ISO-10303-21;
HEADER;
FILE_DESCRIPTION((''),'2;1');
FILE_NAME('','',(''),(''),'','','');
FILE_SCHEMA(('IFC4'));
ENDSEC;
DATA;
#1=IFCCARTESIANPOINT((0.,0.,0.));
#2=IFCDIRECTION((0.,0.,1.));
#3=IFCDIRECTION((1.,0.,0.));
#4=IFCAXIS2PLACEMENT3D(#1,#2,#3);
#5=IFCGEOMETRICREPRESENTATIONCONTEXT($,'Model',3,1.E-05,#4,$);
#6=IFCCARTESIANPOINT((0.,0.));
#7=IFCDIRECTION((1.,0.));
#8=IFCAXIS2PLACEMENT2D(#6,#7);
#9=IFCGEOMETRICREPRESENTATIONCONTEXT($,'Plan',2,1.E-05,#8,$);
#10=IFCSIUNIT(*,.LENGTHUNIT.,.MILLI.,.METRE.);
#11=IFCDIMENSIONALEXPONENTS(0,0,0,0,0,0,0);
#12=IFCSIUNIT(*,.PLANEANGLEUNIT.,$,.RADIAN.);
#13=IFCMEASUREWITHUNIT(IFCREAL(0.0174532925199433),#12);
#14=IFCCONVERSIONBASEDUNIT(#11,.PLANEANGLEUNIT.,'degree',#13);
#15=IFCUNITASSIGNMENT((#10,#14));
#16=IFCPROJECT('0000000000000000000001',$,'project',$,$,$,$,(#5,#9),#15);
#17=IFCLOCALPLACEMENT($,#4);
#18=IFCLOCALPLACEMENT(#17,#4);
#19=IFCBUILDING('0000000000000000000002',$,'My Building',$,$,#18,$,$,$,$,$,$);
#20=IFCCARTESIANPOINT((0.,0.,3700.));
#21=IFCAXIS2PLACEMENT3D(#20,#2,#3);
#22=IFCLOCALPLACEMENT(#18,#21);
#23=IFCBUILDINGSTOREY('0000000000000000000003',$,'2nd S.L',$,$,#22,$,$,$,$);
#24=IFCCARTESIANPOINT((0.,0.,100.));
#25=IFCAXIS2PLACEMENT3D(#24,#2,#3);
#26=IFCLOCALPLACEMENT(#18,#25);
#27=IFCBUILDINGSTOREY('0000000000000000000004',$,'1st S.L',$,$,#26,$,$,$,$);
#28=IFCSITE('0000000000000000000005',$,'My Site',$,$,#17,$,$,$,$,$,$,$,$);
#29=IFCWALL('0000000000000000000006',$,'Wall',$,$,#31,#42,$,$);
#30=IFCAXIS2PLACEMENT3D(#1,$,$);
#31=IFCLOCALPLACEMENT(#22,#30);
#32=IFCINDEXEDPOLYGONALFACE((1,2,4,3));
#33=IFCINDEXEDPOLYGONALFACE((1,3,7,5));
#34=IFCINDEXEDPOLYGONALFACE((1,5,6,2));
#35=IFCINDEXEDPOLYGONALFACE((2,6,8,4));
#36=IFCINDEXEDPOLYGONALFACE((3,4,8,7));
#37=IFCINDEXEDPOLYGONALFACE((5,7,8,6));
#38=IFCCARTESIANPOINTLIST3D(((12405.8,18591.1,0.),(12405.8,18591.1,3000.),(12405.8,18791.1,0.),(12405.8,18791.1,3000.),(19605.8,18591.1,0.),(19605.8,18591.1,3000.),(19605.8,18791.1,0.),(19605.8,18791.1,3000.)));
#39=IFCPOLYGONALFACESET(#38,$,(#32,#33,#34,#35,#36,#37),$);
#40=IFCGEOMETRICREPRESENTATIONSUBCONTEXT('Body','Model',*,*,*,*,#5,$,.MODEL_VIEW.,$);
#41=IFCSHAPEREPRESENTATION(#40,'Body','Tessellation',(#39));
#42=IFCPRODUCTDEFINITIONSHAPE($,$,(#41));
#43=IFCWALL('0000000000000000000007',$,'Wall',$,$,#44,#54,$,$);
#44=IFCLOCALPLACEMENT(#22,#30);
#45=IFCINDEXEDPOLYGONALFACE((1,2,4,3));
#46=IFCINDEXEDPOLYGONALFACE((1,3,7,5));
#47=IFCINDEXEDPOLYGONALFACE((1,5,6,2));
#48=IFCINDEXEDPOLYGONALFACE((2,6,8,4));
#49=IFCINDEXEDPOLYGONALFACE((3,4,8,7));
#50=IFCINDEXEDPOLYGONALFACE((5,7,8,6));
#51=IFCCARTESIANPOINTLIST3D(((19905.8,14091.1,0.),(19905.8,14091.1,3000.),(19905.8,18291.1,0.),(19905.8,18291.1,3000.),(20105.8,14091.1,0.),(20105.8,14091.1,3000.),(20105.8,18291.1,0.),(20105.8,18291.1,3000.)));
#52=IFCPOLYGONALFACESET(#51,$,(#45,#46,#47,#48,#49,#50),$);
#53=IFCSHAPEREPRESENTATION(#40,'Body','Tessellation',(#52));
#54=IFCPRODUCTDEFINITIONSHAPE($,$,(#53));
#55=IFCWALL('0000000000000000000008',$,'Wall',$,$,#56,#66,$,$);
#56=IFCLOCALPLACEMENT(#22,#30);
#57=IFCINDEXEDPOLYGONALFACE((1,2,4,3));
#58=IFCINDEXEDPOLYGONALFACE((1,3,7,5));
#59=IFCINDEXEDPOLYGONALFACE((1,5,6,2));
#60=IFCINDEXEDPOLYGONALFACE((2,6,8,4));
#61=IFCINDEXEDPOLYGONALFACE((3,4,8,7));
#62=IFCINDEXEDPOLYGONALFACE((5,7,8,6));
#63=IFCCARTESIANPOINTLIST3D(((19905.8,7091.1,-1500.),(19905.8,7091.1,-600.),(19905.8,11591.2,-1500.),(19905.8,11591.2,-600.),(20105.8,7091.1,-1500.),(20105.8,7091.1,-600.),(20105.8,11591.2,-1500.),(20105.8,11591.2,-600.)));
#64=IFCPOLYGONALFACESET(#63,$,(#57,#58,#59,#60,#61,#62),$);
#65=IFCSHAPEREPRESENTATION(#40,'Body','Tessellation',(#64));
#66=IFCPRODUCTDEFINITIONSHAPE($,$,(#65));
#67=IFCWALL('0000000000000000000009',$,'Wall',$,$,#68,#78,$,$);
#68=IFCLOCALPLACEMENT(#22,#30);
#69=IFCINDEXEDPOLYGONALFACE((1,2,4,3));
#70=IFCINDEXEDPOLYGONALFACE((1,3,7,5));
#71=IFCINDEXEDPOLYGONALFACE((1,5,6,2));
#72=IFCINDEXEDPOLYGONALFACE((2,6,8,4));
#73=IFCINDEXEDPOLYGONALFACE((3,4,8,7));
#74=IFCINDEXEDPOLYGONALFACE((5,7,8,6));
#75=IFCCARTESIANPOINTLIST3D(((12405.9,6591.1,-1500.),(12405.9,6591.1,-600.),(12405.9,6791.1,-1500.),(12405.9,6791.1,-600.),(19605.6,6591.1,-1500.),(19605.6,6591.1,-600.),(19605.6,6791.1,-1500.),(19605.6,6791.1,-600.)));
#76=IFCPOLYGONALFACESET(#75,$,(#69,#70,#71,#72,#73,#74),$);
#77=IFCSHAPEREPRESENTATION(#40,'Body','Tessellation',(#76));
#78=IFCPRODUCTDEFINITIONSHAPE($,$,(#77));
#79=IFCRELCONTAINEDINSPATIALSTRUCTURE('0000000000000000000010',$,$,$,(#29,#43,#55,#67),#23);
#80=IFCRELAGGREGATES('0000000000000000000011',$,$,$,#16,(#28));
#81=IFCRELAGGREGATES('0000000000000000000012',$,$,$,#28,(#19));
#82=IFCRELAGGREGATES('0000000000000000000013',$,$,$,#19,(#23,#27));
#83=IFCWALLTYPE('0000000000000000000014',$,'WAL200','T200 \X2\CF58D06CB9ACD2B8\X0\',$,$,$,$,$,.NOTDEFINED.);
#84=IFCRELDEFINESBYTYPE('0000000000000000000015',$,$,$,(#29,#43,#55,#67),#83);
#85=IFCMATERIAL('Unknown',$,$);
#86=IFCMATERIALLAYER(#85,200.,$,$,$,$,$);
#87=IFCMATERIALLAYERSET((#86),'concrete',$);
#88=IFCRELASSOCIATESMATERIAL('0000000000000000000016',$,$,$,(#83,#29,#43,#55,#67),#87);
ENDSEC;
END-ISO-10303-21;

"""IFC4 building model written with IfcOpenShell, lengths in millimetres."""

from ifc_helpers import new_model, entity, si_unit, converted_unit, frame, origin_with_axes, origin_2d_with_axis, place, context, subcontext, project, spatial, indexed_curve, outline, extrude, material, layer, layer_set, layer_usage, type_object, element, save


model = new_model("IFC4")

# Units and contexts
model_context = context("Model", 3, precision=1e-05, world=origin_with_axes())
plan_context = context("Plan", 2, precision=1e-05, world=origin_2d_with_axis())
body_context_1 = subcontext(model_context, "Body", "Model", "MODEL_VIEW")
ifc_project = project(units=[si_unit("LENGTHUNIT", "METRE", prefix="MILLI"), converted_unit("PLANEANGLEUNIT", "degree", entity("IfcReal", 0.0174532925199433), si_unit("PLANEANGLEUNIT", "RADIAN"), dimensions=[0, 0, 0, 0, 0, 0, 0])], contexts=[model_context, plan_context])

# Site, building, storey
site_placement = place(None, origin_with_axes())
site = spatial("IfcSite", under=ifc_project, at=site_placement, Name="My Site")
building_placement = place(site_placement, origin_with_axes())
building = spatial("IfcBuilding", under=site, at=building_placement, Name="My Building")
storey_1_placement = place(building_placement, frame((0.0, 0.0, 3700.0), z_axis=(0.0, 0.0, 1.0), x_axis=(1.0, 0.0, 0.0)))
storey_1 = spatial("IfcBuildingStorey", under=building, at=storey_1_placement, Name="2nd S.L")

# Shared definitions
ifc_material_1 = material(Name="Unknown")

# Shared definitions
ifc_layer = layer(ifc_material_1, 200.0)
ifc_layer_set = layer_set([ifc_layer], Name="concrete")
wall_type = type_object("IfcWallType", Name="WAL200", Description="T200 콘크리트", PredefinedType="NOTDEFINED", material=ifc_layer_set)

# Shared definitions
storey_2_placement = place(building_placement, frame((0.0, 0.0, 100.0), z_axis=(0.0, 0.0, 1.0), x_axis=(1.0, 0.0, 0.0)))
storey_2 = spatial("IfcBuildingStorey", under=building, at=storey_2_placement, Name="1st S.L")

# Walls
ifc_layer_usage_1 = layer_usage(ifc_layer_set, "AXIS2", "POSITIVE", 0.0)
wall_1_placement = place(storey_1_placement, frame((12405.8, 18591.1, 0.0), z_axis=(0.0, 0.0, 1.0), x_axis=(1.0, 0.0, 0.0)))
element("IfcWall", 1, at=wall_1_placement, inside=storey_1, type_object=wall_type, material=ifc_layer_usage_1, Name="Wall", context=body_context_1, shape_type="SweptSolid", body=[
    extrude(outline(indexed_curve([(0.0, 0.0), (0.0, 200.0), (7200.0, 200.0), (7200.0, 0.0), (0.0, 0.0)], self_intersect=False)), origin_with_axes(), (0.0, 0.0, 1.0), 3000.0),
])
ifc_layer_usage_2 = layer_usage(ifc_layer_set, "AXIS2", "POSITIVE", 0.0)
wall_2_placement = place(storey_1_placement, frame((20105.8, 14091.1, 0.0), z_axis=(0.0, 0.0, 1.0), x_axis=(0.0, 1.0, 0.0)))
element("IfcWall", 2, at=wall_2_placement, inside=storey_1, type_object=wall_type, material=ifc_layer_usage_2, Name="Wall", context=body_context_1, shape_type="SweptSolid", body=[
    extrude(outline(indexed_curve([(0.0, 0.0), (0.0, 200.0), (4200.0, 200.0), (4200.0, 0.0), (0.0, 0.0)], self_intersect=False)), origin_with_axes(), (0.0, 0.0, 1.0), 3000.0),
])
ifc_layer_usage_3 = layer_usage(ifc_layer_set, "AXIS2", "POSITIVE", 0.0)
wall_3_placement = place(storey_1_placement, frame((20105.8, 7091.1, -1500.0), z_axis=(0.0, 0.0, 1.0), x_axis=(0.0, 1.0, 0.0)))
element("IfcWall", 3, at=wall_3_placement, inside=storey_1, type_object=wall_type, material=ifc_layer_usage_3, Name="Wall", context=body_context_1, shape_type="SweptSolid", body=[
    extrude(outline(indexed_curve([(0.0, 0.0), (0.0, 200.0), (4500.1, 200.0), (4500.1, 0.0), (0.0, 0.0)], self_intersect=False)), origin_with_axes(), (0.0, 0.0, 1.0), 900.0),
])
ifc_layer_usage_4 = layer_usage(ifc_layer_set, "AXIS2", "POSITIVE", 0.0)
wall_4_placement = place(storey_1_placement, frame((19605.6, 6791.1, -1500.0), z_axis=(0.0, 0.0, 1.0), x_axis=(-1.0, 0.0, 0.0)))
element("IfcWall", 4, at=wall_4_placement, inside=storey_1, type_object=wall_type, material=ifc_layer_usage_4, Name="Wall", context=body_context_1, shape_type="SweptSolid", body=[
    extrude(outline(indexed_curve([(0.0, 0.0), (0.0, 200.0), (7199.8, 200.0), (7199.8, 0.0), (0.0, 0.0)], self_intersect=False)), origin_with_axes(), (0.0, 0.0, 1.0), 900.0),
])

save(model, "model.ifc")
